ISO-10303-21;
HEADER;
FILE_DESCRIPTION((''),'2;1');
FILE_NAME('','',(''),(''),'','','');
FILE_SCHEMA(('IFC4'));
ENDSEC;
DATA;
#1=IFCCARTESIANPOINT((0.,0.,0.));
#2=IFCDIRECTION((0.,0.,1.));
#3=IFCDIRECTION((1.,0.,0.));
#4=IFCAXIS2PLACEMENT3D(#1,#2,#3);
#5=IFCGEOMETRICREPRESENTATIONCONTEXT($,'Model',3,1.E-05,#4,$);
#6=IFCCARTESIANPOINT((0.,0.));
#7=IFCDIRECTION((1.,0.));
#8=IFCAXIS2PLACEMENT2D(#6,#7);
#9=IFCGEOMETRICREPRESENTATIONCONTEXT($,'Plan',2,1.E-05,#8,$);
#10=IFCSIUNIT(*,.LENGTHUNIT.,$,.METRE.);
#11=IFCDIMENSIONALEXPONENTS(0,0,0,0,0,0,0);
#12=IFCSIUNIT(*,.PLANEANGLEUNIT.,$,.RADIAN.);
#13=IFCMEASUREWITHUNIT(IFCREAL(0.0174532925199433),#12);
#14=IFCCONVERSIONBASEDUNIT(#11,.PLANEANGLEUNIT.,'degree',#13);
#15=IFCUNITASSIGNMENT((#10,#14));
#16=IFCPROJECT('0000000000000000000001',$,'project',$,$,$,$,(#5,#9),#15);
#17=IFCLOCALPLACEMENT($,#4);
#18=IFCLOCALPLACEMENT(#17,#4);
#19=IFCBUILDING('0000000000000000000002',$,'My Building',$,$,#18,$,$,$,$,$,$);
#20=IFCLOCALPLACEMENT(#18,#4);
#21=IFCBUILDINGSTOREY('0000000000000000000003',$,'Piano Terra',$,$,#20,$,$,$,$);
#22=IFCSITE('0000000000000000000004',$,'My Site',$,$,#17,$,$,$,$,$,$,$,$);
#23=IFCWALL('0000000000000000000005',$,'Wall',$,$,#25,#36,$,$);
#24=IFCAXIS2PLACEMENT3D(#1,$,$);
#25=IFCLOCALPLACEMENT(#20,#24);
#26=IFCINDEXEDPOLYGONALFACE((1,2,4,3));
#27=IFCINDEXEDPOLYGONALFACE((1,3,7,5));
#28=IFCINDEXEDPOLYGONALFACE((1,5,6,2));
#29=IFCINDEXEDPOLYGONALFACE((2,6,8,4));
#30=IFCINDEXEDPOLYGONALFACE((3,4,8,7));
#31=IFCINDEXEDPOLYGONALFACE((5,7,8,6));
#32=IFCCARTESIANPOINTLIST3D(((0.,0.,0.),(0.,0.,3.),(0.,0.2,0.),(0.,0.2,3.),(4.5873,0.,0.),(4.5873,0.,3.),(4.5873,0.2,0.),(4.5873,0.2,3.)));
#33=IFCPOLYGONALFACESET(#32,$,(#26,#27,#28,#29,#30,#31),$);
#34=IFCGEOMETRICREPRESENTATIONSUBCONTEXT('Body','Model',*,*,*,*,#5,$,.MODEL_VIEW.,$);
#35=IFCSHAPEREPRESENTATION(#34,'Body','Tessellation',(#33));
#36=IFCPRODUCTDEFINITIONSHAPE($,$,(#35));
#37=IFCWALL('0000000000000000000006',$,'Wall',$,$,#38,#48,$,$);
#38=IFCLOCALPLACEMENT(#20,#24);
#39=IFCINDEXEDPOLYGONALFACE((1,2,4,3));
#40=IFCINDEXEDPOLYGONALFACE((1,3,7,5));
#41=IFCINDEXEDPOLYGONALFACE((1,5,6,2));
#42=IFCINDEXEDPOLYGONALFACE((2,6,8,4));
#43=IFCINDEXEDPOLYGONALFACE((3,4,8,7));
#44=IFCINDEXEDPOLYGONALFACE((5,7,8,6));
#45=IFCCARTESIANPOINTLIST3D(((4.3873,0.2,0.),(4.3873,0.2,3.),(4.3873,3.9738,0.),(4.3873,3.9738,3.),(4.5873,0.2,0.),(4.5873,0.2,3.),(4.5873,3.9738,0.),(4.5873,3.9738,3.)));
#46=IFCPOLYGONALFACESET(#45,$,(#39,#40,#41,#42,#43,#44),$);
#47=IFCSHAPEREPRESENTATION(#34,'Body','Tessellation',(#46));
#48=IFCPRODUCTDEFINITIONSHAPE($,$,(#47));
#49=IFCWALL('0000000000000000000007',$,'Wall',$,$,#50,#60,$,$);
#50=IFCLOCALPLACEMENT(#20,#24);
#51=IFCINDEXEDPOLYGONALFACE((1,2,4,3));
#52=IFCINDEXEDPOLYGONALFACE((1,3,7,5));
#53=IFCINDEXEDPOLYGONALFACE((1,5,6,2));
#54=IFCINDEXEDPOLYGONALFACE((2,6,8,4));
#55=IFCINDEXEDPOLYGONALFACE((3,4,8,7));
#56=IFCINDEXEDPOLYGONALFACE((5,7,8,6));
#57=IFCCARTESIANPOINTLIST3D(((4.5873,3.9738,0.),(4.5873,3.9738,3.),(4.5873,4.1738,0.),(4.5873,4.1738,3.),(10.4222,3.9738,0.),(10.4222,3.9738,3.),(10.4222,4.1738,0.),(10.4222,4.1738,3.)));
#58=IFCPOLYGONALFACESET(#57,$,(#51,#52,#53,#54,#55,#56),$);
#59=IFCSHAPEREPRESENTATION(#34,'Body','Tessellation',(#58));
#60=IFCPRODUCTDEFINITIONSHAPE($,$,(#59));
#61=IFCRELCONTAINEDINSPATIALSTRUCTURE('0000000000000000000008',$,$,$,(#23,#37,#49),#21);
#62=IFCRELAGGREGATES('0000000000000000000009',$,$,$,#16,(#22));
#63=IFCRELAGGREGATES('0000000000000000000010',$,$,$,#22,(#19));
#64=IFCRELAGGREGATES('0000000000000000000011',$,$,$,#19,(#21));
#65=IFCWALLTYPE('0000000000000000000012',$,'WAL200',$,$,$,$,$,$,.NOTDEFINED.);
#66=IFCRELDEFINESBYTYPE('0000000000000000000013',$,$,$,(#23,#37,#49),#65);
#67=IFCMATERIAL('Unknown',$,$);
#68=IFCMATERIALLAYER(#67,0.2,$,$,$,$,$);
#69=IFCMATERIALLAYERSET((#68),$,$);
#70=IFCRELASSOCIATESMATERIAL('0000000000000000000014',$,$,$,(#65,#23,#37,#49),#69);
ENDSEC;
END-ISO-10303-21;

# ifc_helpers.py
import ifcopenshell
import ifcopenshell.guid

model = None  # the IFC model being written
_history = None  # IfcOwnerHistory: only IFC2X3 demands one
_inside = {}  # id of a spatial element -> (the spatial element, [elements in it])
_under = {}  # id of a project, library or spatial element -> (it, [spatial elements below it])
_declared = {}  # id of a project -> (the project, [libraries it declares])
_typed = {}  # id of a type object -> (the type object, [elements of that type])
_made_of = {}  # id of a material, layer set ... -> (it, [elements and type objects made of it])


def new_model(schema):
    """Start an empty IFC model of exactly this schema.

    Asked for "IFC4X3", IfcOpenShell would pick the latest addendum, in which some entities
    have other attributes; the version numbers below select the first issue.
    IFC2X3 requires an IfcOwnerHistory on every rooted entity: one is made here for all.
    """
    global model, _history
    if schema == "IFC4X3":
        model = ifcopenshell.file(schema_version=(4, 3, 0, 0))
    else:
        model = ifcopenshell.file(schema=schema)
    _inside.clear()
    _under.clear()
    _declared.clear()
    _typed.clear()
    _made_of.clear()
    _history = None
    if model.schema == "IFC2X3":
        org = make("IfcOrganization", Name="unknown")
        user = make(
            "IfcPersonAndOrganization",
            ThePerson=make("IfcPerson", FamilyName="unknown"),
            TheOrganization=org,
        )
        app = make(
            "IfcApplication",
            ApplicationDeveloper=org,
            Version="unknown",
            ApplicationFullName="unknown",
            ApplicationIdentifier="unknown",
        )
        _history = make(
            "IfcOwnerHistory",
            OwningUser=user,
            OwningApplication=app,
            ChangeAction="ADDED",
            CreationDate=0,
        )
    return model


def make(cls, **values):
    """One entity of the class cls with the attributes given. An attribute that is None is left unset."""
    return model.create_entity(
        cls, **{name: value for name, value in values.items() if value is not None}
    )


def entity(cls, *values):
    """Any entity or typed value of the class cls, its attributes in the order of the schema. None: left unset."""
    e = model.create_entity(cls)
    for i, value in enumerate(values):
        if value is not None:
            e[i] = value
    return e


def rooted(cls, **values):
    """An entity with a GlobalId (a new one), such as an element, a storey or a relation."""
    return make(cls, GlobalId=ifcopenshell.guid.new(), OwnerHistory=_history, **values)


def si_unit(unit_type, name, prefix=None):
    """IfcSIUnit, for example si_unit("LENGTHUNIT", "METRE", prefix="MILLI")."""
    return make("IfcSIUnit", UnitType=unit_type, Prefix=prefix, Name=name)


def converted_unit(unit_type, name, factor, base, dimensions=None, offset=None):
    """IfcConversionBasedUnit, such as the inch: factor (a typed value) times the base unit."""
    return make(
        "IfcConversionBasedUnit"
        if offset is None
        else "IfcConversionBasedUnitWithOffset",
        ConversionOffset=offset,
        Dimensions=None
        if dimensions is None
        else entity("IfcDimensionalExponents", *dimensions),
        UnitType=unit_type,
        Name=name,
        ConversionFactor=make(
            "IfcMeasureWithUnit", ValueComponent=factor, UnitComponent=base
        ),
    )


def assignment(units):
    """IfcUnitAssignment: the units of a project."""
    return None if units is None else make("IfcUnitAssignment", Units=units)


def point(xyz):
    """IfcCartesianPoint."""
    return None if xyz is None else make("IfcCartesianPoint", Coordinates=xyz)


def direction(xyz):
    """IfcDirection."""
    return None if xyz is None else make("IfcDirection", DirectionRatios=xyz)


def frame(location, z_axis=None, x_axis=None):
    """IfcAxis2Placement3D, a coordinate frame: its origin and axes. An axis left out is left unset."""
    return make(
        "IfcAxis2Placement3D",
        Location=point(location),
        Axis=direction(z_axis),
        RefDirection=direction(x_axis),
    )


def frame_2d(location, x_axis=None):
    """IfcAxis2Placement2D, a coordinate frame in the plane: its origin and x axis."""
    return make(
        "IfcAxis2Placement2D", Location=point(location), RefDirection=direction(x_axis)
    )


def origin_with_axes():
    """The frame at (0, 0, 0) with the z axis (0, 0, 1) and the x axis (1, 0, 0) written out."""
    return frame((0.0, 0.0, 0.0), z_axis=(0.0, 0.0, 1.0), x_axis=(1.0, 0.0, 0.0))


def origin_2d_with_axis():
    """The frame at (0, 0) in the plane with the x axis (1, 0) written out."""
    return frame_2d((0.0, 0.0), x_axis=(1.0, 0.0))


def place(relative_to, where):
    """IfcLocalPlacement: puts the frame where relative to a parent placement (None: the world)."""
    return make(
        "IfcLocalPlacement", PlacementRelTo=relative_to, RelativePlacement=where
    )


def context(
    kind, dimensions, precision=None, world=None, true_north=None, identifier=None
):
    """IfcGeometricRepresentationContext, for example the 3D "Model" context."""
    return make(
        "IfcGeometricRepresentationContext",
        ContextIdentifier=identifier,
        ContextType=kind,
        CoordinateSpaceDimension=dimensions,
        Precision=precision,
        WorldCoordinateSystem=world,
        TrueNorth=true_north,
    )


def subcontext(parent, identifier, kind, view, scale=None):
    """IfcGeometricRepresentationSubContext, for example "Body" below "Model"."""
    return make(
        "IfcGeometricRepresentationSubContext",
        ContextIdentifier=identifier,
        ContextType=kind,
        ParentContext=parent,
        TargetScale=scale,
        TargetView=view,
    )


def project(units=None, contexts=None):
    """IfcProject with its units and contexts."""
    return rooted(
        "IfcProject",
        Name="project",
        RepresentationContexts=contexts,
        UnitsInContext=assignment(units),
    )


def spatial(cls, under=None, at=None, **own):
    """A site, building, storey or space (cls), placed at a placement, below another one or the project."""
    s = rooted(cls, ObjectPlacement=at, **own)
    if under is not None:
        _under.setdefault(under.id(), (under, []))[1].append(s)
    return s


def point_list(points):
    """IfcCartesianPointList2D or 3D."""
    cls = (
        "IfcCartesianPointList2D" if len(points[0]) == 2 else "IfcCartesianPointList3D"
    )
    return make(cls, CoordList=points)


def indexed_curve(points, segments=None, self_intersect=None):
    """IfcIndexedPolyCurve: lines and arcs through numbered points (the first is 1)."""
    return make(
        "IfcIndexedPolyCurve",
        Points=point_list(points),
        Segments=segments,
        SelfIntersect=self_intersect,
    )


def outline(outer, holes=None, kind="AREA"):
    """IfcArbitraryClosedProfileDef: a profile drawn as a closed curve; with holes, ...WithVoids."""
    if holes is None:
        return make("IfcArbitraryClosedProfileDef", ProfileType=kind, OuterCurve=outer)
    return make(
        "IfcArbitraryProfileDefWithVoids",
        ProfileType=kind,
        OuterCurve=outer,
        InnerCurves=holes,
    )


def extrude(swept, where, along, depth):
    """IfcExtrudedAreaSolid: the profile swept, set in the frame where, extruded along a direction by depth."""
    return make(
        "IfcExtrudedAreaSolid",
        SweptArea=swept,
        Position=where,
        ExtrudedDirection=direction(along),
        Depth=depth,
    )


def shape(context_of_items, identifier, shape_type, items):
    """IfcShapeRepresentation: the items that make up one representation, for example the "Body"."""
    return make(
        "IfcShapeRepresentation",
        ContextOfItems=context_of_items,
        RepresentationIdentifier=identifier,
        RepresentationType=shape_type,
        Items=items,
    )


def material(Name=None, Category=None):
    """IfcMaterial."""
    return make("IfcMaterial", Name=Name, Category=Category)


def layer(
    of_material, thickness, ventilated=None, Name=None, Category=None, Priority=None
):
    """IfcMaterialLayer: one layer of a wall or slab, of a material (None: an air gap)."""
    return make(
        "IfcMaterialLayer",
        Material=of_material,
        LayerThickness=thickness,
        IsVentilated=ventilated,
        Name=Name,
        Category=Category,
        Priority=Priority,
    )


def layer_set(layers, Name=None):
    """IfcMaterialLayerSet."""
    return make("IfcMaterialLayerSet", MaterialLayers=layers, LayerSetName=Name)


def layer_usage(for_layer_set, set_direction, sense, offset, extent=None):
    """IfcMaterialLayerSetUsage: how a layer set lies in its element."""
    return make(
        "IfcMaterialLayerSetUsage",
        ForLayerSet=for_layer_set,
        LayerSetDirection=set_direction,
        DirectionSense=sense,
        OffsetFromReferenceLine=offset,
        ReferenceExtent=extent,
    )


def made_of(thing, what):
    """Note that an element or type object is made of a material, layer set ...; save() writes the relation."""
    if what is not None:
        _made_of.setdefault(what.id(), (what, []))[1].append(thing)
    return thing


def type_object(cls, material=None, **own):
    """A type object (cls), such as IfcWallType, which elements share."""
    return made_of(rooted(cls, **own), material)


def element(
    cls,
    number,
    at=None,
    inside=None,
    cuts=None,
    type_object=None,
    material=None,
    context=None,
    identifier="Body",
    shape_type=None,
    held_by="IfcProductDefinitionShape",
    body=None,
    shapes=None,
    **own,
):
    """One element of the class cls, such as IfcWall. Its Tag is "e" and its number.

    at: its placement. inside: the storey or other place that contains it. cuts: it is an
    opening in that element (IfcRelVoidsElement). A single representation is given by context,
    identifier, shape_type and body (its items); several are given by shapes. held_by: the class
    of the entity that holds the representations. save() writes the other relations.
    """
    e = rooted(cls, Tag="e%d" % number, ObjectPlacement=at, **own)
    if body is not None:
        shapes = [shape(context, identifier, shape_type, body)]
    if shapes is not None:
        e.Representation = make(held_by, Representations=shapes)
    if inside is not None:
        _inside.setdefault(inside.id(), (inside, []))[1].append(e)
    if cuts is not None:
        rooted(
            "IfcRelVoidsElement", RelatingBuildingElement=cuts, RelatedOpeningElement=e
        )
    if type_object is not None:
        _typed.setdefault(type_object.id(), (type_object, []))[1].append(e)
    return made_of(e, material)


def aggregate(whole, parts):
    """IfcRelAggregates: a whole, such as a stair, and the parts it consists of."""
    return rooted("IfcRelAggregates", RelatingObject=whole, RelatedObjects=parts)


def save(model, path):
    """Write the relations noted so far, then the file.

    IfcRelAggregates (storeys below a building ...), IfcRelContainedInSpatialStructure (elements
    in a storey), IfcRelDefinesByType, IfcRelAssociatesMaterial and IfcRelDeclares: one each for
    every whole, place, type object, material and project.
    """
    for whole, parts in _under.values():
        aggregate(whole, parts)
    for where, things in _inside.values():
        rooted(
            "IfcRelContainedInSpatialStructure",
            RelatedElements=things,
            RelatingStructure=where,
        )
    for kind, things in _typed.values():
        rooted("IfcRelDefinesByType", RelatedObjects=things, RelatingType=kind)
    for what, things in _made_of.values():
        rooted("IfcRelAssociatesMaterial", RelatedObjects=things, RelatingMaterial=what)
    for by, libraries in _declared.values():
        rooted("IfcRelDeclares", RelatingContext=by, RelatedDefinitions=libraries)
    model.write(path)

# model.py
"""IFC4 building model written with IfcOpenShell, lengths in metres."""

from ifc_helpers import new_model, entity, si_unit, converted_unit, frame, origin_with_axes, origin_2d_with_axis, place, context, subcontext, project, spatial, indexed_curve, outline, extrude, material, layer, layer_set, layer_usage, type_object, element, save


model = new_model("IFC4")

# Units and contexts
model_context = context("Model", 3, precision=1e-05, world=origin_with_axes())
plan_context = context("Plan", 2, precision=1e-05, world=origin_2d_with_axis())
body_context = subcontext(model_context, "Body", "Model", "MODEL_VIEW")
ifc_project = project(units=[si_unit("LENGTHUNIT", "METRE"), converted_unit("PLANEANGLEUNIT", "degree", entity("IfcReal", 0.0174532925199433), si_unit("PLANEANGLEUNIT", "RADIAN"), dimensions=[0, 0, 0, 0, 0, 0, 0])], contexts=[model_context, plan_context])

# Site, building, storey
site_placement = place(None, origin_with_axes())
site = spatial("IfcSite", under=ifc_project, at=site_placement, Name="My Site")
building_placement = place(site_placement, origin_with_axes())
building = spatial("IfcBuilding", under=site, at=building_placement, Name="My Building")
storey_placement = place(building_placement, origin_with_axes())
storey = spatial("IfcBuildingStorey", under=building, at=storey_placement, Name="Piano Terra")

# Walls
ifc_material = material(Name="Unknown")
ifc_layer = layer(ifc_material, 0.2)
ifc_layer_set = layer_set([ifc_layer])
ifc_layer_usage_1 = layer_usage(ifc_layer_set, "AXIS2", "POSITIVE", 0.0)
wall_type = type_object("IfcWallType", Name="WAL200", PredefinedType="NOTDEFINED", material=ifc_layer_set)
wall_1_placement = place(storey_placement, origin_with_axes())
element("IfcWall", 1, at=wall_1_placement, inside=storey, type_object=wall_type, material=ifc_layer_usage_1, Name="Wall", context=body_context, shape_type="SweptSolid", body=[
    extrude(outline(indexed_curve([(0.0, 0.0), (0.0, 0.2), (4.5873, 0.2), (4.5873, 0.0), (0.0, 0.0)], self_intersect=False)), origin_with_axes(), (0.0, 0.0, 1.0), 3.0),
])
ifc_layer_usage_2 = layer_usage(ifc_layer_set, "AXIS2", "POSITIVE", 0.0)
wall_2_placement = place(storey_placement, frame((4.5873, 0.2, 0.0), z_axis=(0.0, 0.0, 1.0), x_axis=(0.0, 1.0, 0.0)))
element("IfcWall", 2, at=wall_2_placement, inside=storey, type_object=wall_type, material=ifc_layer_usage_2, Name="Wall", context=body_context, shape_type="SweptSolid", body=[
    extrude(outline(indexed_curve([(0.0, 0.0), (0.0, 0.2), (3.7738, 0.2), (3.7738, 0.0), (0.0, 0.0)], self_intersect=False)), origin_with_axes(), (0.0, 0.0, 1.0), 3.0),
])
ifc_layer_usage_3 = layer_usage(ifc_layer_set, "AXIS2", "POSITIVE", 0.0)
wall_3_placement = place(storey_placement, frame((4.5873, 3.9738, 0.0), z_axis=(0.0, 0.0, 1.0), x_axis=(1.0, 0.0, 0.0)))
element("IfcWall", 3, at=wall_3_placement, inside=storey, type_object=wall_type, material=ifc_layer_usage_3, Name="Wall", context=body_context, shape_type="SweptSolid", body=[
    extrude(outline(indexed_curve([(0.0, 0.0), (0.0, 0.2), (5.8349, 0.2), (5.8349, 0.0), (0.0, 0.0)], self_intersect=False)), origin_with_axes(), (0.0, 0.0, 1.0), 3.0),
])

save(model, "model.ifc")
